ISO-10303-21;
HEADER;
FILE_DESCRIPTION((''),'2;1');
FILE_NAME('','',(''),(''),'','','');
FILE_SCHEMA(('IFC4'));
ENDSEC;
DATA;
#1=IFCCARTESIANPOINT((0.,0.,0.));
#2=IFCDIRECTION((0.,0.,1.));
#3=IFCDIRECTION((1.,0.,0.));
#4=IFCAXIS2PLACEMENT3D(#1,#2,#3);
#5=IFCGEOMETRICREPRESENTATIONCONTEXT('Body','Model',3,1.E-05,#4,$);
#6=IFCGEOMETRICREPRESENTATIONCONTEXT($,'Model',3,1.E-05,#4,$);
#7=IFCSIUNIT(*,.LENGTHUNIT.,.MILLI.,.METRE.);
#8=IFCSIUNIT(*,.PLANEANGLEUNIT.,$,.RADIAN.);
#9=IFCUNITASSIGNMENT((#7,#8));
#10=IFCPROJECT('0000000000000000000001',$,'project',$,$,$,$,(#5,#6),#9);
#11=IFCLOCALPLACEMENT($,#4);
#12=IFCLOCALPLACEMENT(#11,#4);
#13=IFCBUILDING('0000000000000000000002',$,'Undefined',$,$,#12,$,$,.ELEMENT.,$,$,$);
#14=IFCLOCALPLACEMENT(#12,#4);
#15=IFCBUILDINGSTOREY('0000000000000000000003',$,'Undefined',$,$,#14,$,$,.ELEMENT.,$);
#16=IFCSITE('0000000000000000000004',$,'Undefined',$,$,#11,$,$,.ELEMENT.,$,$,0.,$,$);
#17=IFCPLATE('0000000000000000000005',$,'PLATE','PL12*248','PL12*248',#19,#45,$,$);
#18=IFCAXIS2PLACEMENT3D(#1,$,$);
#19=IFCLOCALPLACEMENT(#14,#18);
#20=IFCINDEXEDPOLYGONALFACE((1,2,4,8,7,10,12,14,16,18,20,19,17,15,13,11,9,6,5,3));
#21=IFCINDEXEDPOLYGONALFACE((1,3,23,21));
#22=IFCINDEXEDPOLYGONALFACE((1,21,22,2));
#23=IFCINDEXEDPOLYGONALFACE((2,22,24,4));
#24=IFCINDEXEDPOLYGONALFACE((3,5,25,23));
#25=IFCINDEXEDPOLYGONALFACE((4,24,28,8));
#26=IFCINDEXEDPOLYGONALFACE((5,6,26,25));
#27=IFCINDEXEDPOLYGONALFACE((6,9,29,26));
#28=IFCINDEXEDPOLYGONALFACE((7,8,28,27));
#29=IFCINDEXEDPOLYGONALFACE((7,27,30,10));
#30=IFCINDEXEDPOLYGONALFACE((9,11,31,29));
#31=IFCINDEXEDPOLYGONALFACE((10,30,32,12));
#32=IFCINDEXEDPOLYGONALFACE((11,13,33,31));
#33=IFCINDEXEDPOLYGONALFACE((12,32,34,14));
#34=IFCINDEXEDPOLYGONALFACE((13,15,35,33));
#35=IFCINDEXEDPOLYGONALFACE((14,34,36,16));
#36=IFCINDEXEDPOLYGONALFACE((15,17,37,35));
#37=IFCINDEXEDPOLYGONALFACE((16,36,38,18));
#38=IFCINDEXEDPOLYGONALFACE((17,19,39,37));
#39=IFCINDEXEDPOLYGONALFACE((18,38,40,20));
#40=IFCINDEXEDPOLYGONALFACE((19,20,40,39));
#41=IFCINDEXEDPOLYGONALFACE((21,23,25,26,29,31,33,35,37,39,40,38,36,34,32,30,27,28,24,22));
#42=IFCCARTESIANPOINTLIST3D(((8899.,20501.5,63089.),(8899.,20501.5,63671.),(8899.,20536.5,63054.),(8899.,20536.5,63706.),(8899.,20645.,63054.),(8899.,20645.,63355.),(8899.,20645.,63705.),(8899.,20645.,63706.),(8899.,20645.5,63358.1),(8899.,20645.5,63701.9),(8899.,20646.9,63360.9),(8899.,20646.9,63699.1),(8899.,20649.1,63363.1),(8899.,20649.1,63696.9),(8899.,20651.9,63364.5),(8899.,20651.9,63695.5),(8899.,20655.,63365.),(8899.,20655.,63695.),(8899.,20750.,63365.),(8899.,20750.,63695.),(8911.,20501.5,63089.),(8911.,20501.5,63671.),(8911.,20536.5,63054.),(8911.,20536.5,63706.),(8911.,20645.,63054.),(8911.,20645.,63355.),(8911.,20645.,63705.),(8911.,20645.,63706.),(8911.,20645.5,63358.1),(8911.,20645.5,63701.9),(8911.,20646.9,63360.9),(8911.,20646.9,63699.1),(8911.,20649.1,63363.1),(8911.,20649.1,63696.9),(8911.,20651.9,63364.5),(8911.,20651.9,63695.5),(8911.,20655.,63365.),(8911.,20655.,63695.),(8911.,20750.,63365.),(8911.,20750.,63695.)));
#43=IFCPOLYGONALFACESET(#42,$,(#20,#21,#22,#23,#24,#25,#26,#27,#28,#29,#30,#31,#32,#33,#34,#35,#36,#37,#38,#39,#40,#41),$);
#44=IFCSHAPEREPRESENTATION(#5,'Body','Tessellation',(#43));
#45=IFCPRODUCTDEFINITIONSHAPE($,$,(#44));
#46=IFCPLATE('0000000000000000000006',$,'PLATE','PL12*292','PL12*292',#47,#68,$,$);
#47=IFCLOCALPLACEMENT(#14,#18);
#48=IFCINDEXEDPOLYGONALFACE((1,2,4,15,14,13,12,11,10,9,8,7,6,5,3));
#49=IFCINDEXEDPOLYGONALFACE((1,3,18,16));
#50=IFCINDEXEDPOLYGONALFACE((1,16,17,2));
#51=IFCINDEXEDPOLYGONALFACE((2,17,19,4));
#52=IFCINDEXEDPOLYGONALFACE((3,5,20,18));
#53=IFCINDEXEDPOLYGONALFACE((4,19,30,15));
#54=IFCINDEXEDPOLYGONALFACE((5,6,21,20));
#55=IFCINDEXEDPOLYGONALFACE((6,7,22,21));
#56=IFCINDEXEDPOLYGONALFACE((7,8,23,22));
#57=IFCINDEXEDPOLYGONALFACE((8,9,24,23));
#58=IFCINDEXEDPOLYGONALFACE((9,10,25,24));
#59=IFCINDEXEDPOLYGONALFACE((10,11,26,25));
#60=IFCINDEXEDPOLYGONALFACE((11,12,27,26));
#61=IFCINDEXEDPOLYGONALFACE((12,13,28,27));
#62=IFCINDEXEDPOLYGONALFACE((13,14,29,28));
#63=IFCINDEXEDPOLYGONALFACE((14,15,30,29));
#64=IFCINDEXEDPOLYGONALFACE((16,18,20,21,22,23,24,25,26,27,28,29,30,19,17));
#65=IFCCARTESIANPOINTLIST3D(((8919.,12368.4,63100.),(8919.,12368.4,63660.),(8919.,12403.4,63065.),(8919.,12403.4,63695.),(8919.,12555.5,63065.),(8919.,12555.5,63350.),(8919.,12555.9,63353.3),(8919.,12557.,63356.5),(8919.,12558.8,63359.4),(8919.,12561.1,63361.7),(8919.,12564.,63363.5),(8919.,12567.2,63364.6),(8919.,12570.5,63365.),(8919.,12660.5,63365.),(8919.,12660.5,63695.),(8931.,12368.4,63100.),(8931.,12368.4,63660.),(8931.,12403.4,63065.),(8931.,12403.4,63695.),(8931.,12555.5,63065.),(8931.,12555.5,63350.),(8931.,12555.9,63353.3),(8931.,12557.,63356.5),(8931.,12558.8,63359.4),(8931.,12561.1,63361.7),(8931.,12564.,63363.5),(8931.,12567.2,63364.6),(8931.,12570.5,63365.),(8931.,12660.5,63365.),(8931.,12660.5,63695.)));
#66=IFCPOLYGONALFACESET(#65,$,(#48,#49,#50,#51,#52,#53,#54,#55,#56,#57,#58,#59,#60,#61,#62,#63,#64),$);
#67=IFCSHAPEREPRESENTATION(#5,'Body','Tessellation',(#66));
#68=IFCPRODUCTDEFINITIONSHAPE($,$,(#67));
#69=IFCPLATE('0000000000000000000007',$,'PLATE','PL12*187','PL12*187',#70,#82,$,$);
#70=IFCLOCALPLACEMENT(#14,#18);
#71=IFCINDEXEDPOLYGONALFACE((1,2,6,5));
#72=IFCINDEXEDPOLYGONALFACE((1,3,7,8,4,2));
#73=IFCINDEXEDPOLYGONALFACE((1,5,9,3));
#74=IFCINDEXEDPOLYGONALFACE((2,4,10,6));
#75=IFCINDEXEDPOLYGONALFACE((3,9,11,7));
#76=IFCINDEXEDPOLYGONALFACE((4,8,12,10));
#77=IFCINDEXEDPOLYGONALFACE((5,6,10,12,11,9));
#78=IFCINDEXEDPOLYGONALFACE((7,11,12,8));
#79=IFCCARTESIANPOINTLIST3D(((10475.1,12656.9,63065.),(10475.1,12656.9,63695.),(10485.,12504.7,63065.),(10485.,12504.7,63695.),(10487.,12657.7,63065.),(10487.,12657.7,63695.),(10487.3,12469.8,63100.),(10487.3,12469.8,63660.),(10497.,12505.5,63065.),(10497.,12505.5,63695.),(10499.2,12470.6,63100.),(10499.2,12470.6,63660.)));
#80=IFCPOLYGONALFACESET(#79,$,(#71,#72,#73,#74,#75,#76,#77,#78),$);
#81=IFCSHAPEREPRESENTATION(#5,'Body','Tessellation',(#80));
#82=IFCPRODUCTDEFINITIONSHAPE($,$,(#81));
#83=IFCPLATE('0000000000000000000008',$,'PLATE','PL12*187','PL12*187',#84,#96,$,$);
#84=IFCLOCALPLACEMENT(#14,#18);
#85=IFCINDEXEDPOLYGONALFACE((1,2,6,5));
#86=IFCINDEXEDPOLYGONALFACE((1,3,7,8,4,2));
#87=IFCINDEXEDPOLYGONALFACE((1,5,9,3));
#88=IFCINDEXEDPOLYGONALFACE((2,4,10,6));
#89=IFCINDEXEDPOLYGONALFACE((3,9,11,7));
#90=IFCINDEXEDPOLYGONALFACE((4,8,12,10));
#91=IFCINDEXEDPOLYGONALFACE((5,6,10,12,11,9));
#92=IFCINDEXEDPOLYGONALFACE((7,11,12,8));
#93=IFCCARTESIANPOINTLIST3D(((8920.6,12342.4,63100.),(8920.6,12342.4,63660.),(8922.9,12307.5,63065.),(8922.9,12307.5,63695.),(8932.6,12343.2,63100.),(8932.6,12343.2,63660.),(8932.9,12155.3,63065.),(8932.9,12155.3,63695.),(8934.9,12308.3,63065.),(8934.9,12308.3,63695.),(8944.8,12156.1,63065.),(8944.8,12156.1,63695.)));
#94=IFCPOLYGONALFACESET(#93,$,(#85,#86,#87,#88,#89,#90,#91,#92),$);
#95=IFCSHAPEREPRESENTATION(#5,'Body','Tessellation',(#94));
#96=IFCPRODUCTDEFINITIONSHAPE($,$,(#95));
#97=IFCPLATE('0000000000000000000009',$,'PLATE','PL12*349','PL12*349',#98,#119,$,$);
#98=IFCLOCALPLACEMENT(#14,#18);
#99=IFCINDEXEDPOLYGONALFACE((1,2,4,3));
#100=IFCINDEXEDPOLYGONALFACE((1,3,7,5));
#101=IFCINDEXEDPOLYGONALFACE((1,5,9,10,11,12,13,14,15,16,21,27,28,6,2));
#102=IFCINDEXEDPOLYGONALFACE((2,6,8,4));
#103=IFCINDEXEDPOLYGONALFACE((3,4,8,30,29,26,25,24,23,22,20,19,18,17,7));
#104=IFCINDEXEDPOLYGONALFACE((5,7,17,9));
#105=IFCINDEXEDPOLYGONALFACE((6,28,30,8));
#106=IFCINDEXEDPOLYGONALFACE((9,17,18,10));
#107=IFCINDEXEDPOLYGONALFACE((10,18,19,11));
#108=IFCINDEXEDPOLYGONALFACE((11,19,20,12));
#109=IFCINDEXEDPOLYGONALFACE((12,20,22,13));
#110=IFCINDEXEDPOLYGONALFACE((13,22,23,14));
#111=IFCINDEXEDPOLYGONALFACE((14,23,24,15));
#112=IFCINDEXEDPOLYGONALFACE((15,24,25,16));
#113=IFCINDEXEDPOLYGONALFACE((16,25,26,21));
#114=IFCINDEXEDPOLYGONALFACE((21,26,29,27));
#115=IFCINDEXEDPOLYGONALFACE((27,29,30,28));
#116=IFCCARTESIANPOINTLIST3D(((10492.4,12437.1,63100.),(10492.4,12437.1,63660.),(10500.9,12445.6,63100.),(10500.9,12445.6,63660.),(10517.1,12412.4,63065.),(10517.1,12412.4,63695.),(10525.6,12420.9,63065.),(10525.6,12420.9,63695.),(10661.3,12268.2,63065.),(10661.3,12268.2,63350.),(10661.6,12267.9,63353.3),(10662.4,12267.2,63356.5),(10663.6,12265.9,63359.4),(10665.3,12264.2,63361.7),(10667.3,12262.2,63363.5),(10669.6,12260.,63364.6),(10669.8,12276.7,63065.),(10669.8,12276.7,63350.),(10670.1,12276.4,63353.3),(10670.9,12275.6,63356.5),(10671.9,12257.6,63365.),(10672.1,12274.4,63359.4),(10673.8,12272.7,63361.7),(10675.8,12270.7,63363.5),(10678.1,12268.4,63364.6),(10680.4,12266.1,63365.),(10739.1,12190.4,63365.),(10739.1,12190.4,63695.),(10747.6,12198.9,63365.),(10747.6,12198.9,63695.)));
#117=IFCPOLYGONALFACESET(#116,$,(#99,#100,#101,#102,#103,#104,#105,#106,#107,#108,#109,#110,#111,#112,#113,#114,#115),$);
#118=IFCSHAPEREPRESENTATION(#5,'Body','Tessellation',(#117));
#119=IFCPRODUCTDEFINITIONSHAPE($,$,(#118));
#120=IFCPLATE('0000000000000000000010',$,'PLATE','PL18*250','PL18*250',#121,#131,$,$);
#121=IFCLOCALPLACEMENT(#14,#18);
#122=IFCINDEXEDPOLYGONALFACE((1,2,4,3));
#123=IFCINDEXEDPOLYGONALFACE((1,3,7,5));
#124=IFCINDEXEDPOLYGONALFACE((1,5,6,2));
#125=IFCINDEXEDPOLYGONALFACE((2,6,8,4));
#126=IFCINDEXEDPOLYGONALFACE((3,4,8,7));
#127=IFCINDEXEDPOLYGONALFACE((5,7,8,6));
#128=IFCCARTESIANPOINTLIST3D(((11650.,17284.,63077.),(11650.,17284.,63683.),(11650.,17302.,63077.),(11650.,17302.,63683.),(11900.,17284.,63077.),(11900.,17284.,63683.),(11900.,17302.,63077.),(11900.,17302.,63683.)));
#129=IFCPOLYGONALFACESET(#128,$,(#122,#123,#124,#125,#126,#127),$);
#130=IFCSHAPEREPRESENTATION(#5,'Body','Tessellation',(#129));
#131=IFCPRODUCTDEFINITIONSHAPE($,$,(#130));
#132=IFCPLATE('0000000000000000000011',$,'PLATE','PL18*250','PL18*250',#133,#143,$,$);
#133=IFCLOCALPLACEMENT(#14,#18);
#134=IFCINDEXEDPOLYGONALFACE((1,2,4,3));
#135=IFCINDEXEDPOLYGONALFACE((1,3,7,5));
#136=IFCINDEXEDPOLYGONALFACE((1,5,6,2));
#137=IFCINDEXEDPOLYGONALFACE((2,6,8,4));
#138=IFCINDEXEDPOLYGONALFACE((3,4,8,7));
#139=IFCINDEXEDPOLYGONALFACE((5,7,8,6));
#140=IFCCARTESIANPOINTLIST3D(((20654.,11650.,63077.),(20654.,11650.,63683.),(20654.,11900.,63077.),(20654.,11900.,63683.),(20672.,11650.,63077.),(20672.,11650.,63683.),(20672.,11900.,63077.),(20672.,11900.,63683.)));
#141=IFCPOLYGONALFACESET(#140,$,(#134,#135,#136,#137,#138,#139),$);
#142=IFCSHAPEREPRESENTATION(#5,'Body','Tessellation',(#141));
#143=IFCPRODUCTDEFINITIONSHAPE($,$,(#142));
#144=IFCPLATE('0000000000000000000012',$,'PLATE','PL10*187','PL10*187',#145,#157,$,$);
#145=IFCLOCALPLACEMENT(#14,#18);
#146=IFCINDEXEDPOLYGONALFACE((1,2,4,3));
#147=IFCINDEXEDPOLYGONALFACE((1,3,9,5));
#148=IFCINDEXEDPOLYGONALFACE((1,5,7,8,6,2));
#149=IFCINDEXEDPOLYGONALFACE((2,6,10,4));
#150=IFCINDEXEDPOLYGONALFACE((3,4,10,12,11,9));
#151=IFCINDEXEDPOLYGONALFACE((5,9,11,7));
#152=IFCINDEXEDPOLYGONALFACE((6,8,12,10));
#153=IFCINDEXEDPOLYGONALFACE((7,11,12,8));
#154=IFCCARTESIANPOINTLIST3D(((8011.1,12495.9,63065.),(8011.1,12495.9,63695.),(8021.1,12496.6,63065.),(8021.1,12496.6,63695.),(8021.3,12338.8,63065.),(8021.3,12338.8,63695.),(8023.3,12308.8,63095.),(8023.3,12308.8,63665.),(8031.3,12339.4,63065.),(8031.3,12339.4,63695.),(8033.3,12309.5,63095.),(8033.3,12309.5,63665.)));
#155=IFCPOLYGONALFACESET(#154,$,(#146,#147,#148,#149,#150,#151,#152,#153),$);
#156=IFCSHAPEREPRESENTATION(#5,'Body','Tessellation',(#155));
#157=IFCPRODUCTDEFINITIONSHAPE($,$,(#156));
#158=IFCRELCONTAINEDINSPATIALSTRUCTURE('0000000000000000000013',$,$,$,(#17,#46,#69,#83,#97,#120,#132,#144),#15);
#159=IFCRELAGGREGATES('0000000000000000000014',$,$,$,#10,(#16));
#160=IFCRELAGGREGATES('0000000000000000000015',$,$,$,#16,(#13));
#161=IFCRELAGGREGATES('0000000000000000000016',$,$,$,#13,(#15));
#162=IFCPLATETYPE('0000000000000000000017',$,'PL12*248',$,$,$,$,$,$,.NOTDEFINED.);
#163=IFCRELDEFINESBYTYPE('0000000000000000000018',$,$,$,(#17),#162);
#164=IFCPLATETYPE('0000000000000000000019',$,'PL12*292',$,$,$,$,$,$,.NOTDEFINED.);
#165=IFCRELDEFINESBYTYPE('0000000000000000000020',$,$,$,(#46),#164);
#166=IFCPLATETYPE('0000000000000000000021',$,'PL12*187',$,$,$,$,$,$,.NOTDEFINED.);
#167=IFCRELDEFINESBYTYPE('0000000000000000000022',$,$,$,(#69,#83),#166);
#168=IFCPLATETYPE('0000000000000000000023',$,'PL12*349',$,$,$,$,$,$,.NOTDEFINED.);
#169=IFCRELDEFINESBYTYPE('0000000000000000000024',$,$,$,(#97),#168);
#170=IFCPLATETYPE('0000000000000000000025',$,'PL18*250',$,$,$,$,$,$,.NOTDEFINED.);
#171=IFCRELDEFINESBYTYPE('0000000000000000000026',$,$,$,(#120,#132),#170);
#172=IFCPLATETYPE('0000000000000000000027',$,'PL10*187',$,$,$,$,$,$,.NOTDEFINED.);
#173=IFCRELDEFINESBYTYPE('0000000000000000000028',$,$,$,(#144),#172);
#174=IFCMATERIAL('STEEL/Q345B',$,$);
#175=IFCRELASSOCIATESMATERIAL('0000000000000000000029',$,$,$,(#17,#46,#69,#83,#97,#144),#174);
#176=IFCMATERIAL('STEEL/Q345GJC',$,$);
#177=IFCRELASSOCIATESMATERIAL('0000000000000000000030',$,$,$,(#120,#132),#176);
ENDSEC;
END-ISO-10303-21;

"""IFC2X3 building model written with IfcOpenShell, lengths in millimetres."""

from ifc_helpers import new_model, si_unit, frame, origin_with_axes, place, context, project, spatial, polyline, outline, extrude, material, type_object, element, save


model = new_model("IFC2X3")

# Units and contexts
model_context_1 = context("Model", 3, precision=1e-05, world=origin_with_axes(), identifier="Body")
model_context_2 = context("Model", 3, precision=1e-05, world=origin_with_axes())
ifc_project = project(units=[si_unit("LENGTHUNIT", "METRE", prefix="MILLI"), si_unit("PLANEANGLEUNIT", "RADIAN")], contexts=[model_context_1, model_context_2])

# Site, building, storey
site_placement = place(None, origin_with_axes())
site = spatial("IfcSite", under=ifc_project, at=site_placement, Name="Undefined", CompositionType="ELEMENT", RefElevation=0.0)
building_placement = place(site_placement, origin_with_axes())
building = spatial("IfcBuilding", under=site, at=building_placement, Name="Undefined", CompositionType="ELEMENT")
storey_placement = place(building_placement, origin_with_axes())
storey = spatial("IfcBuildingStorey", under=building, at=storey_placement, Name="Undefined", CompositionType="ELEMENT")

# Shared definitions
ifc_material_1 = material(Name="STEEL/Q345B")

# Shared definitions
ifc_material_2 = material(Name="STEEL/Q345GJC")

# Plates
plate_type_1 = type_object("IfcPlateType", Name="PL12*248", PredefinedType="NOTDEFINED")
for number, where, z_axis, x_axis, name in (
    (1, (8905.0, 20501.5, 63089.0), (1.0, 0.0, 0.0), (0.0, 0.707107, -0.707107), "PLATE"),
):
    element("IfcPlate", number, at=place(storey_placement, frame(where, z_axis=z_axis, x_axis=x_axis)), inside=storey, type_object=plate_type_1, material=ifc_material_1, Name=name, Description="PL12*248", ObjectType="PL12*248", context=model_context_1, shape_type="SweptSolid", body=[
        extrude(outline(polyline([(0.0, 0.0), (49.5, 0.0), (126.2, 76.7), (-86.6, 289.6), (-88.5, 292.1), (-89.4, 295.1), (-89.4, 298.2), (-88.5, 301.2), (-86.6, 303.7), (-19.4, 370.9), (-252.8, 604.2), (-320.0, 537.0), (-322.5, 535.2), (-325.5, 534.2), (-328.6, 534.2), (-331.6, 535.2), (-334.1, 537.0), (-334.8, 537.8), (-411.5, 461.0), (-411.5, 411.5), (0.0, 0.0)])), frame((0.0, 0.0, -6.0), z_axis=(0.0, 0.0, 1.0), x_axis=(1.0, 0.0, 0.0)), (0.0, 0.0, 1.0), 12.0),
    ])
plate_type_2 = type_object("IfcPlateType", Name="PL12*292", PredefinedType="NOTDEFINED")
plate_1_placement = place(storey_placement, frame((8925.0, 12660.5, 63695.0), z_axis=(1.0, 0.0, 0.0), x_axis=(0.0, -1.0, 0.0)))
element("IfcPlate", 2, at=plate_1_placement, inside=storey, type_object=plate_type_2, material=ifc_material_1, Name="PLATE", Description="PL12*292", ObjectType="PL12*292", context=model_context_1, shape_type="SweptSolid", body=[
    extrude(outline(polyline([(0.0, 0.0), (257.2, 0.0), (292.2, 35.0), (292.2, 595.0), (257.2, 630.0), (105.1, 630.0), (105.1, 345.0), (104.7, 341.7), (103.6, 338.5), (101.8, 335.6), (99.4, 333.3), (96.6, 331.5), (93.4, 330.4), (90.1, 330.0), (0.0, 330.0), (0.0, 0.0)])), frame((0.0, 0.0, -6.0), z_axis=(0.0, 0.0, 1.0), x_axis=(1.0, 0.0, 0.0)), (0.0, 0.0, 1.0), 12.0),
])
plate_type_3 = type_object("IfcPlateType", Name="PL12*187", PredefinedType="NOTDEFINED")
for number, where, z_axis, x_axis, name in (
    (3, (10493.3, 12470.2, 63065.0), (0.997873, 0.065184, 0.0), (-0.065184, 0.997873, 0.0), "PLATE"),
    (4, (8926.6, 12342.8, 63065.0), (-0.997873, -0.065183, 0.0), (0.065183, -0.997873, 0.0), "PLATE"),
):
    element("IfcPlate", number, at=place(storey_placement, frame(where, z_axis=z_axis, x_axis=x_axis)), inside=storey, type_object=plate_type_3, material=ifc_material_1, Name=name, Description="PL12*187", ObjectType="PL12*187", context=model_context_1, shape_type="SweptSolid", body=[
        extrude(outline(polyline([(0.0, 35.0), (35.0, 0.0), (187.5, 0.0), (187.5, 630.0), (35.0, 630.0), (0.0, 595.0), (0.0, 35.0)])), frame((0.0, 0.0, -6.0), z_axis=(0.0, 0.0, 1.0), x_axis=(1.0, 0.0, 0.0)), (0.0, 0.0, 1.0), 12.0),
    ])
plate_type_4 = type_object("IfcPlateType", Name="PL12*349", PredefinedType="NOTDEFINED")
plate_2_placement = place(storey_placement, frame((10743.4, 12194.6, 63695.0), z_axis=(0.707107, 0.707107, 0.0), x_axis=(0.0, 0.0, -1.0)))
element("IfcPlate", 5, at=plate_2_placement, inside=storey, type_object=plate_type_4, material=ifc_material_1, Name="PLATE", Description="PL12*349", ObjectType="PL12*349", context=model_context_1, shape_type="SweptSolid", body=[
    extrude(outline(polyline([(0.0, 0.0), (330.0, 0.0), (330.0, 95.0), (330.4, 98.4), (331.5, 101.5), (333.3, 104.4), (335.6, 106.8), (338.5, 108.5), (341.7, 109.7), (345.0, 110.0), (630.0, 110.0), (630.0, 313.9), (595.0, 348.9), (35.0, 348.9), (0.0, 313.9), (0.0, 0.0)])), frame((0.0, 0.0, -6.0), z_axis=(0.0, 0.0, 1.0), x_axis=(1.0, 0.0, 0.0)), (0.0, 0.0, 1.0), 12.0),
])
plate_type_5 = type_object("IfcPlateType", Name="PL18*250", PredefinedType="NOTDEFINED")
for number, where, z_axis, x_axis, name in (
    (6, (11650.0, 17293.0, 63683.0), (0.0, 1.0, 0.0), (1.0, 0.0, 0.0), "PLATE"),
    (7, (20663.0, 11650.0, 63683.0), (-1.0, 0.0, 0.0), (0.0, 1.0, 0.0), "PLATE"),
):
    element("IfcPlate", number, at=place(storey_placement, frame(where, z_axis=z_axis, x_axis=x_axis)), inside=storey, type_object=plate_type_5, material=ifc_material_2, Name=name, Description="PL18*250", ObjectType="PL18*250", context=model_context_1, shape_type="SweptSolid", body=[
        extrude(outline(polyline([(0.0, 0.0), (250.0, 0.0), (250.0, 606.0), (0.0, 606.0), (0.0, 0.0)])), frame((0.0, 0.0, -9.0), z_axis=(0.0, 0.0, 1.0), x_axis=(1.0, 0.0, 0.0)), (0.0, 0.0, 1.0), 18.0),
    ])
plate_type_6 = type_object("IfcPlateType", Name="PL10*187", PredefinedType="NOTDEFINED")
plate_3_placement = place(storey_placement, frame((8028.3, 12309.2, 63065.0), z_axis=(0.997873, 0.065184, 0.0), x_axis=(-0.065184, 0.997873, 0.0)))
element("IfcPlate", 8, at=plate_3_placement, inside=storey, type_object=plate_type_6, material=ifc_material_1, Name="PLATE", Description="PL10*187", ObjectType="PL10*187", context=model_context_1, shape_type="SweptSolid", body=[
    extrude(outline(polyline([(0.0, 30.0), (30.0, 0.0), (187.5, 0.0), (187.5, 630.0), (30.0, 630.0), (0.0, 600.0), (0.0, 30.0)])), frame((0.0, 0.0, -5.0), z_axis=(0.0, 0.0, 1.0), x_axis=(1.0, 0.0, 0.0)), (0.0, 0.0, 1.0), 10.0),
])

save(model, "model.ifc")
